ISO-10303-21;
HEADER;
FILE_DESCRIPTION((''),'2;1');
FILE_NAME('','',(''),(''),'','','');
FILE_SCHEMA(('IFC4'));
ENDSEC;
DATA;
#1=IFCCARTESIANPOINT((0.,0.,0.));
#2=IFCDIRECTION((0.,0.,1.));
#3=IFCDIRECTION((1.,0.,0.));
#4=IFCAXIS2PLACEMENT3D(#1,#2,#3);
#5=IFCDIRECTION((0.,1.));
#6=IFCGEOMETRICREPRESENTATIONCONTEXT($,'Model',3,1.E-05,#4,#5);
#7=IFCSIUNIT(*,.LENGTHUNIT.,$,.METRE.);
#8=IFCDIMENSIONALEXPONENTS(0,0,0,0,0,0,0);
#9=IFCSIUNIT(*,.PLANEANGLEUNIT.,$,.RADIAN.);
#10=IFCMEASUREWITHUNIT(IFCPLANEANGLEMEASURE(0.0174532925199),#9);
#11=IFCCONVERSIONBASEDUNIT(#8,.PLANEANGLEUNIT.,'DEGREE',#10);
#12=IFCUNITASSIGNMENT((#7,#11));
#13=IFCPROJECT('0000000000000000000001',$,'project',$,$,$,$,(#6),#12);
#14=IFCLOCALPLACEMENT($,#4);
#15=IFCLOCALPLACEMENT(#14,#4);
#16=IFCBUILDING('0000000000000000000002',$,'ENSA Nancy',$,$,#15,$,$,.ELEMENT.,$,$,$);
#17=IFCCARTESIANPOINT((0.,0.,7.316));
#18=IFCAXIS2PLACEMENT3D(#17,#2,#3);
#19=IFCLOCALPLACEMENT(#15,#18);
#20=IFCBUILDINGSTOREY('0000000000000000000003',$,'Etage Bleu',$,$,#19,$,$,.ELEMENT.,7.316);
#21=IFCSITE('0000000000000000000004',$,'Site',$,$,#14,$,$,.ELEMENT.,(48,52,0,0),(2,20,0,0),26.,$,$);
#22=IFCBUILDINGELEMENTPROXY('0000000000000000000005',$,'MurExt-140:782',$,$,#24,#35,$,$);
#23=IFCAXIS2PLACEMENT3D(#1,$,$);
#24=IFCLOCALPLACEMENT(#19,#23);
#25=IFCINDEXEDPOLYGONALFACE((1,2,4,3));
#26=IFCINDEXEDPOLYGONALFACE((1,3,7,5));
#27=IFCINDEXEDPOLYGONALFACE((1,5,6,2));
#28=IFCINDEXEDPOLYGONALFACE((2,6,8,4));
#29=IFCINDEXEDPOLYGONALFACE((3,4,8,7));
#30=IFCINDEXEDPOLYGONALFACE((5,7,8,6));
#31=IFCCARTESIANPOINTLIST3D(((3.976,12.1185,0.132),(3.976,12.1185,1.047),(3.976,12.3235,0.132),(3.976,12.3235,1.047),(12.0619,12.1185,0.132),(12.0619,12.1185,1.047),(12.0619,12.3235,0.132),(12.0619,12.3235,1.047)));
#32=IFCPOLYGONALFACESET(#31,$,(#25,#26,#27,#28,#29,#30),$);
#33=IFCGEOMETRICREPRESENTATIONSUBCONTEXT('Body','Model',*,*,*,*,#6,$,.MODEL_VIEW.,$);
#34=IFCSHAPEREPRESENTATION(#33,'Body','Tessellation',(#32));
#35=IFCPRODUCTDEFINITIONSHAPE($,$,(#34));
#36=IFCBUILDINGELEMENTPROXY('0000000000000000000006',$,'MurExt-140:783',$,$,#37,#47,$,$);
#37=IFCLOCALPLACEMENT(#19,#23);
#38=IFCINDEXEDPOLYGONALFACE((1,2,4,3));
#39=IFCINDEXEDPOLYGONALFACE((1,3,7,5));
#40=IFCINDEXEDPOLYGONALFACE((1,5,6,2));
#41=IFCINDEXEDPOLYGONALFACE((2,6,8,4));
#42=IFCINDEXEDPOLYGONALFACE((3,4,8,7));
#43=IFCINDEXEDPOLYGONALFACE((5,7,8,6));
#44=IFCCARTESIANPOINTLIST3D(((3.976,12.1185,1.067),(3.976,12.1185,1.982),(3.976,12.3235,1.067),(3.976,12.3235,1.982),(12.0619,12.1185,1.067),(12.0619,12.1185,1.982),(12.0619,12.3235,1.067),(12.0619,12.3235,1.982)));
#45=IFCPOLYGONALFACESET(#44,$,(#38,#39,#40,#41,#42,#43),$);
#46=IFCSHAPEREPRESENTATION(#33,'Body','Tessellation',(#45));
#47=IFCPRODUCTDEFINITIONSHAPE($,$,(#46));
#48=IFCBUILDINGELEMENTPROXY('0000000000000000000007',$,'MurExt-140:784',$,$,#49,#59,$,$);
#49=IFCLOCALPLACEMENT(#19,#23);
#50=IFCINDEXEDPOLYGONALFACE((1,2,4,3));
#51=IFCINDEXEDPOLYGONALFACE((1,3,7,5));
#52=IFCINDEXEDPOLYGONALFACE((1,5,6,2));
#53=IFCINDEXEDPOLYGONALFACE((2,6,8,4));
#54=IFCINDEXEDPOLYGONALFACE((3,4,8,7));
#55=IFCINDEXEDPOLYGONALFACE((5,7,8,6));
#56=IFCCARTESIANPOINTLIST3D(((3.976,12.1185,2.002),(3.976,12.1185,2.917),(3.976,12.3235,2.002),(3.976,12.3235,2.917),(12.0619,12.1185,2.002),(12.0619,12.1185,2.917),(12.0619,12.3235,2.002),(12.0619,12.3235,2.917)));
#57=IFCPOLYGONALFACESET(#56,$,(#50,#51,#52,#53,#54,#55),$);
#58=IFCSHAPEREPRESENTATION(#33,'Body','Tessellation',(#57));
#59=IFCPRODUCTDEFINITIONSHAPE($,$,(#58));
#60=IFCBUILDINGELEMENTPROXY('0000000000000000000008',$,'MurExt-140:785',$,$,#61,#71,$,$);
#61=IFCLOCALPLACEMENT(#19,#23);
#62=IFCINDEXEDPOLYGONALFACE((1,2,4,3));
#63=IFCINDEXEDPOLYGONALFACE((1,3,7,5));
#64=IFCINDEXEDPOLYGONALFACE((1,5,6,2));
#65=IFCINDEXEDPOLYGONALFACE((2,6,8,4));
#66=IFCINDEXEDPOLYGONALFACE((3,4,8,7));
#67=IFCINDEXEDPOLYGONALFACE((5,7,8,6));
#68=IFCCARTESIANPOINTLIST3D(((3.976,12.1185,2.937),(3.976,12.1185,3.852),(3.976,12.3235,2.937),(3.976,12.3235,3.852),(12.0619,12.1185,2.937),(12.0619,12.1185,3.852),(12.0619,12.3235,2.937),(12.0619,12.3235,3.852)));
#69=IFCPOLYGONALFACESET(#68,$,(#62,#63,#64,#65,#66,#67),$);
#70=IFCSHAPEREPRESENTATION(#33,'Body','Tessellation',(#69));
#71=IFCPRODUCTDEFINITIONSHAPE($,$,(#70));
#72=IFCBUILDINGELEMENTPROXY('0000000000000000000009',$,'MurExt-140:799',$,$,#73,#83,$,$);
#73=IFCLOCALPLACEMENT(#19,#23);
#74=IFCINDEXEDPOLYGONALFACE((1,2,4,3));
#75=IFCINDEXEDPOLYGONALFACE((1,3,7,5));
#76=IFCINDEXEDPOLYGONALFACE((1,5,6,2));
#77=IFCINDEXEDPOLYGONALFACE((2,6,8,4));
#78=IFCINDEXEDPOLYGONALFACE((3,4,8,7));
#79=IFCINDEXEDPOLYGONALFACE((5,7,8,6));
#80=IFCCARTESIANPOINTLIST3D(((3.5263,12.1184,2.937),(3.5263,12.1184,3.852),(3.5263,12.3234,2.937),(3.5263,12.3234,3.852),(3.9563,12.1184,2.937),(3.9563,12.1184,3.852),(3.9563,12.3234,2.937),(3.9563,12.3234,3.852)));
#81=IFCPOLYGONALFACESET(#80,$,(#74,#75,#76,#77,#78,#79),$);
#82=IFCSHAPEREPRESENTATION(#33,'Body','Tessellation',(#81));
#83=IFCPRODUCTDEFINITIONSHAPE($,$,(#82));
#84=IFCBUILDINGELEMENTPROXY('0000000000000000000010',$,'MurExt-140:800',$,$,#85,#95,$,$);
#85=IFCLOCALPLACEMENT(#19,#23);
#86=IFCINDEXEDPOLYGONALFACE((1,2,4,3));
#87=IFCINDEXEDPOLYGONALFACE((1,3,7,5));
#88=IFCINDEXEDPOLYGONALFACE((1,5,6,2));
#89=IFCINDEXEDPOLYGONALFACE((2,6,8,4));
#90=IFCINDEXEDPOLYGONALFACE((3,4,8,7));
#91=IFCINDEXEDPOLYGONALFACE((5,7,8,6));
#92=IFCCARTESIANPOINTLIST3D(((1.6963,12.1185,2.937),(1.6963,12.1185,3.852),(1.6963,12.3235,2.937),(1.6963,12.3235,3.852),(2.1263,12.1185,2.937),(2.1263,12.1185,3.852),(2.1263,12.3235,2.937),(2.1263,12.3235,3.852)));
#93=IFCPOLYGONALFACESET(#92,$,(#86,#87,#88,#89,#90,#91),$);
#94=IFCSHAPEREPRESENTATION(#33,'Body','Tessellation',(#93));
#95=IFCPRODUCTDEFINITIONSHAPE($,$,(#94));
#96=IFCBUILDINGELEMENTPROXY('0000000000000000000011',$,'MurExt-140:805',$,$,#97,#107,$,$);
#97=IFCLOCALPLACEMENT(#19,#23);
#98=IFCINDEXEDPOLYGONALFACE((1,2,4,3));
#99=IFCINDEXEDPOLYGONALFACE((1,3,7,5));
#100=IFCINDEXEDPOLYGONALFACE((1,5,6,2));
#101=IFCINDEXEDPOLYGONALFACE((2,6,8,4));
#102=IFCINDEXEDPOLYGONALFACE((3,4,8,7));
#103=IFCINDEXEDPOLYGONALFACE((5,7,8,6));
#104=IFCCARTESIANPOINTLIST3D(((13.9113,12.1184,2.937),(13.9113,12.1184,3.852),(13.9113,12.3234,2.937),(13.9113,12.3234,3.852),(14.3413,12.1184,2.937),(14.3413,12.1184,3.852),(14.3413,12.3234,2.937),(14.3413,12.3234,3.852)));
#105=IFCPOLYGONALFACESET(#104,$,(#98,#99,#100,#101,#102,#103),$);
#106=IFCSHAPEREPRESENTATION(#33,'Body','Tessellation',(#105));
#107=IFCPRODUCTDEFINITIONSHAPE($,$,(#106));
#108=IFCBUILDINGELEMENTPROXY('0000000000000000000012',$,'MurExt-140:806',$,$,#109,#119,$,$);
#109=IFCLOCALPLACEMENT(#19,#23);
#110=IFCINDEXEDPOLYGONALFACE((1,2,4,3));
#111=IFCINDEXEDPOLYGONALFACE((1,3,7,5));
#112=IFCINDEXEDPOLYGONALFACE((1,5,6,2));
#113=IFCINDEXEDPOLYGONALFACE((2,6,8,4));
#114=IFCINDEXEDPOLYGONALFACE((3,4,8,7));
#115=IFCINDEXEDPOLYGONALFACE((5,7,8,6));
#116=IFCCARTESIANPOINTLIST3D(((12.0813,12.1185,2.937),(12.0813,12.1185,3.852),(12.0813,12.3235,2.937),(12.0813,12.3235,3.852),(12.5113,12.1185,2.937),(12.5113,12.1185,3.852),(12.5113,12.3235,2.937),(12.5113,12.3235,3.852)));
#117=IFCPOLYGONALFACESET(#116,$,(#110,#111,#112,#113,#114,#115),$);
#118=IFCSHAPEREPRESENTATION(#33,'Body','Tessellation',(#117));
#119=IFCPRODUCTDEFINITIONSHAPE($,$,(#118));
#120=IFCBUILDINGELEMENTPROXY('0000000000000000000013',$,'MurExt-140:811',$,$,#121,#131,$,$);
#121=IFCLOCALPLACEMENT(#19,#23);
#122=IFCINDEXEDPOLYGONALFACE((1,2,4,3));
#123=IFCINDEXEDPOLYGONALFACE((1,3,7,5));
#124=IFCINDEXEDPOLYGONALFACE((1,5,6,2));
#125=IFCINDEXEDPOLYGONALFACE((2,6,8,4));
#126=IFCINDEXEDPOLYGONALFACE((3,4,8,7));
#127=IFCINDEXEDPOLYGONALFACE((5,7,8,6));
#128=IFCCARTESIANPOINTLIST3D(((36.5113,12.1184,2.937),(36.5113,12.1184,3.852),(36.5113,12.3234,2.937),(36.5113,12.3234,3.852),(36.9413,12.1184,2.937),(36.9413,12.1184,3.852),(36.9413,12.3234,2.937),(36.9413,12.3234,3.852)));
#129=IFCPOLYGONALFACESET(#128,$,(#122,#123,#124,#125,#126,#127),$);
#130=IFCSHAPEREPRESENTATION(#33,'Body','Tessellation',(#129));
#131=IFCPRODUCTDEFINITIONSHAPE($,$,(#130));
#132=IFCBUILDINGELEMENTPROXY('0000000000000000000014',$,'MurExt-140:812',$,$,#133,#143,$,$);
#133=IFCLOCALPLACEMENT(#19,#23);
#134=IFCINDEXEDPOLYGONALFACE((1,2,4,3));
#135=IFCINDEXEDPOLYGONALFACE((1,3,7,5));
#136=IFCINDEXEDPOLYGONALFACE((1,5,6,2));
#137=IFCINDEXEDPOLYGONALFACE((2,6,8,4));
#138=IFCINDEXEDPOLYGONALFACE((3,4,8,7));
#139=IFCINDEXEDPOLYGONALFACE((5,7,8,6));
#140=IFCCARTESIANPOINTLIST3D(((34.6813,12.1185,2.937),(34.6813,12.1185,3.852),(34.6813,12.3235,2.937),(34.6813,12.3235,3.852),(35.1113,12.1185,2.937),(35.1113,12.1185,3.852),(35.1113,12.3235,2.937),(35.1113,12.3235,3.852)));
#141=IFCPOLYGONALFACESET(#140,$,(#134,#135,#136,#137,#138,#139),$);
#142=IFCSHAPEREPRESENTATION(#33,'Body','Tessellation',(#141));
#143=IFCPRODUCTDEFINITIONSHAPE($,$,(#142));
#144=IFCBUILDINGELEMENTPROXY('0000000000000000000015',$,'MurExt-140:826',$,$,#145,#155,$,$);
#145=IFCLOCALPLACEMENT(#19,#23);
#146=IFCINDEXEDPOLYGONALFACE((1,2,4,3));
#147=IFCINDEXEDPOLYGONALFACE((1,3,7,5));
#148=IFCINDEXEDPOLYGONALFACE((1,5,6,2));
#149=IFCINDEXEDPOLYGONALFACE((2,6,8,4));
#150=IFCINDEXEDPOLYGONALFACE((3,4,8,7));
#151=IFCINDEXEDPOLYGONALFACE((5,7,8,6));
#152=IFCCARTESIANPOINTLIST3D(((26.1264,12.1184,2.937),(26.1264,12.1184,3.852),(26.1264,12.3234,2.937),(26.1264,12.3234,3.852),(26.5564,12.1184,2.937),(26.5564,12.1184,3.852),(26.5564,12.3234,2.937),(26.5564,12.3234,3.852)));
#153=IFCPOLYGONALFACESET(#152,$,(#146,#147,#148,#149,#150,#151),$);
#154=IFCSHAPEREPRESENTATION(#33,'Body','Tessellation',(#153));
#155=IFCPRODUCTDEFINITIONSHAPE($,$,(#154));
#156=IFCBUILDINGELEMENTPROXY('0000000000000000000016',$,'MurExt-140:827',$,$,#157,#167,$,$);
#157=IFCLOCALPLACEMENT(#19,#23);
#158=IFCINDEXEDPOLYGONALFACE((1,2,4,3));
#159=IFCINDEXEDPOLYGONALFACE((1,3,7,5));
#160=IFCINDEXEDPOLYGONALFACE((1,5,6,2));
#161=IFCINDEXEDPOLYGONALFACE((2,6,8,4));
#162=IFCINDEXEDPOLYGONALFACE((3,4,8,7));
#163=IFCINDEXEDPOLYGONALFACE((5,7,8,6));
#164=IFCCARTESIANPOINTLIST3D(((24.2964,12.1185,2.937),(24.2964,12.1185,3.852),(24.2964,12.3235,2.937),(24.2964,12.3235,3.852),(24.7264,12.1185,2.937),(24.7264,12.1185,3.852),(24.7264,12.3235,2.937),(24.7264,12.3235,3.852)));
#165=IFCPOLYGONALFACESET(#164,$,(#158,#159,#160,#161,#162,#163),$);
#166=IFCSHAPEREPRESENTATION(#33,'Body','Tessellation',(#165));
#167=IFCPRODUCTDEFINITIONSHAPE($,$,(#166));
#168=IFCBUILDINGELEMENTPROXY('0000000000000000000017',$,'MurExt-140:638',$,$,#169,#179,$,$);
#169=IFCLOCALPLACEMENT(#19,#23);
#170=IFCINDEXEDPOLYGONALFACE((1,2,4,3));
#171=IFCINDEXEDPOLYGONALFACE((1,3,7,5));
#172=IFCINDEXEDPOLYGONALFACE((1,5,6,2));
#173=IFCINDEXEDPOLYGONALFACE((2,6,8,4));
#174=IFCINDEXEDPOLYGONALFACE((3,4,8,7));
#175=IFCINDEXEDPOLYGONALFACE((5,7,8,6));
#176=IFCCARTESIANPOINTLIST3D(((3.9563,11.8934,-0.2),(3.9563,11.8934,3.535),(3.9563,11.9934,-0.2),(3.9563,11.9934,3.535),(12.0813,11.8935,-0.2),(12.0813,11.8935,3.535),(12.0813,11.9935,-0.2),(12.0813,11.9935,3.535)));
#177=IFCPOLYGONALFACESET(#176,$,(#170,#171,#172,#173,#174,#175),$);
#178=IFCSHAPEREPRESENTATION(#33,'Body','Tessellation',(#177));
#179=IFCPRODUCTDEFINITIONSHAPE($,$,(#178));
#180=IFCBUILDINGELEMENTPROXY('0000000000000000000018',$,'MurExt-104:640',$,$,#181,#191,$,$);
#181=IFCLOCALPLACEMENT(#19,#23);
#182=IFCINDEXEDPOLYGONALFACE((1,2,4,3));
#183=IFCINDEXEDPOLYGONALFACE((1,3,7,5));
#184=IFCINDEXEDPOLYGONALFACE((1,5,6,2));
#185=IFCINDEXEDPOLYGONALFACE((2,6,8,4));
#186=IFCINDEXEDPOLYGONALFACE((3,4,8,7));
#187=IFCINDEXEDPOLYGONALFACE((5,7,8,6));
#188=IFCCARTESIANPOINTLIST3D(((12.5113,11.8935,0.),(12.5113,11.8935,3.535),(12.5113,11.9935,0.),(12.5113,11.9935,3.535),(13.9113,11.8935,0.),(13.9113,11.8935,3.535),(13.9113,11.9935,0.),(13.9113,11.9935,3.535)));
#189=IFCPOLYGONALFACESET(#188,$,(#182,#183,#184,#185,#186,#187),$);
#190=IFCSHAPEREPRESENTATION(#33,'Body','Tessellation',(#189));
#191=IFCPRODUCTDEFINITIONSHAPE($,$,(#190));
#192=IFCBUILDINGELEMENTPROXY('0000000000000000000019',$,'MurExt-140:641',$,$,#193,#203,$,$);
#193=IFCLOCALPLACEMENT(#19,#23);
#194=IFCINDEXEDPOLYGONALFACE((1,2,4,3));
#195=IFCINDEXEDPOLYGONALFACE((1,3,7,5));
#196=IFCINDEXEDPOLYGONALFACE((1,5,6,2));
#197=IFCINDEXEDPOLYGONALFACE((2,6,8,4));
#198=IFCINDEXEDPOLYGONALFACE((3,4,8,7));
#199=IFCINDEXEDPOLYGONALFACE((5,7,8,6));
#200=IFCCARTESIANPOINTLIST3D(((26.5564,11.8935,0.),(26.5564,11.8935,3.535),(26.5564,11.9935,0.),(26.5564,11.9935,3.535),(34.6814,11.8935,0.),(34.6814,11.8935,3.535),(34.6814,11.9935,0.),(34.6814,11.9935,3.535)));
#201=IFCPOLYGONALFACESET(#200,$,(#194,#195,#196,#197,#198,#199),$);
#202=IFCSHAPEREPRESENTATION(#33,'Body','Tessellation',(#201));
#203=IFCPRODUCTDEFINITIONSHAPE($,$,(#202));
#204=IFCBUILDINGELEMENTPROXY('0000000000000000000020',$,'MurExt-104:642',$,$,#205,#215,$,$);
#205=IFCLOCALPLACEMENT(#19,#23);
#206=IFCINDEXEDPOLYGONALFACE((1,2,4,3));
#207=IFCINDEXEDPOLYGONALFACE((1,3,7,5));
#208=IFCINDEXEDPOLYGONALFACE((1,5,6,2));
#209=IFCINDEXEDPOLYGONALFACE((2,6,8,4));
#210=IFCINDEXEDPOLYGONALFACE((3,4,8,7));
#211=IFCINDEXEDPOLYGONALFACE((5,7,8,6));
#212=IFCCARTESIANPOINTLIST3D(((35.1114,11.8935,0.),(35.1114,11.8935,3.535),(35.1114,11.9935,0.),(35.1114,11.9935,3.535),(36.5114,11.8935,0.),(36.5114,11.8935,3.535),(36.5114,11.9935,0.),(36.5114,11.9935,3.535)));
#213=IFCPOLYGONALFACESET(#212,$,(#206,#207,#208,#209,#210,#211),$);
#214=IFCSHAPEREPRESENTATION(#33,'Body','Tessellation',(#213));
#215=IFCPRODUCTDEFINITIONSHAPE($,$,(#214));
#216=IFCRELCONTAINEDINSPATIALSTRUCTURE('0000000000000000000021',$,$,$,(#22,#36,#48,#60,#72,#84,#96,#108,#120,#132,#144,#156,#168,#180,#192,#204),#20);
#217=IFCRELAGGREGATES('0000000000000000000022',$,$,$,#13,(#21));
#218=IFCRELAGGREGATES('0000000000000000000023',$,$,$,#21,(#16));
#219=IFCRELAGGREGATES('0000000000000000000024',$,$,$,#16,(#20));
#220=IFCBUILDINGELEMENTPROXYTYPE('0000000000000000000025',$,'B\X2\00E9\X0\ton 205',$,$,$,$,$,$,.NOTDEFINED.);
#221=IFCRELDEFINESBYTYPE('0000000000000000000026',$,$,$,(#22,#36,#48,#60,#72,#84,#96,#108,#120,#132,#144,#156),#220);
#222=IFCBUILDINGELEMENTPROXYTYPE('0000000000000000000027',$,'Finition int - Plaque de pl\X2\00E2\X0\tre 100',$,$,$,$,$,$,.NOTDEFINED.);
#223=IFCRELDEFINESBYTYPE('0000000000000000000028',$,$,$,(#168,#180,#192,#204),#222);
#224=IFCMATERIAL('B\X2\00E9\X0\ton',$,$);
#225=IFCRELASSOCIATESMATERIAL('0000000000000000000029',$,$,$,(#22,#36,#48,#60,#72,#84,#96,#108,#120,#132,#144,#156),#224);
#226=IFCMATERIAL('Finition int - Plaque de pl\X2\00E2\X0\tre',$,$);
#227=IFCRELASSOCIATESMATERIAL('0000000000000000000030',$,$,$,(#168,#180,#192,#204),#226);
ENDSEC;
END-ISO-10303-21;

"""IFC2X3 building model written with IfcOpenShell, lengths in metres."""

from ifc_helpers import new_model, entity, si_unit, converted_unit, direction, frame, origin_with_axes, place, context, subcontext, project, spatial, polyline, outline, extrude, material, type_object, element, save


model = new_model("IFC2X3")

# Units and contexts
model_context = context("Model", 3, precision=1e-05, world=origin_with_axes(), true_north=direction((0.0, 1.0)))
body_context = subcontext(model_context, "Body", "Model", "MODEL_VIEW")
ifc_project = project(units=[si_unit("LENGTHUNIT", "METRE"), converted_unit("PLANEANGLEUNIT", "DEGREE", entity("IfcPlaneAngleMeasure", 0.0174532925199), si_unit("PLANEANGLEUNIT", "RADIAN"), dimensions=[0, 0, 0, 0, 0, 0, 0])], contexts=[model_context])

# Site, building, storey
site_placement = place(None, origin_with_axes())
site = spatial("IfcSite", under=ifc_project, at=site_placement, Name="Site", CompositionType="ELEMENT", RefLatitude=(48, 52, 0, 0), RefLongitude=(2, 20, 0, 0), RefElevation=26.0)
building_placement = place(site_placement, origin_with_axes())
building = spatial("IfcBuilding", under=site, at=building_placement, Name="ENSA Nancy", CompositionType="ELEMENT")
storey_placement = place(building_placement, frame((0.0, 0.0, 7.316), z_axis=(0.0, 0.0, 1.0), x_axis=(1.0, 0.0, 0.0)))
storey = spatial("IfcBuildingStorey", under=building, at=storey_placement, Name="Etage Bleu", CompositionType="ELEMENT", Elevation=7.316)

# Shared definitions
ifc_material_1 = material(Name="Finition int - Plaque de plâtre")

# Shared definitions
ifc_material_2 = material(Name="Béton")

# Building element proxies
building_element_proxy_type_1 = type_object("IfcBuildingElementProxyType", Name="Béton 205", PredefinedType="NOTDEFINED")
for number, where, z_axis, x_axis, name in (
    (1, (3.976, 12.3235, 0.132), (0.0, 0.0, 1.0), (1.0, 0.0, 0.0), "MurExt-140:782"),
    (2, (3.976, 12.3235, 1.067), (0.0, 0.0, 1.0), (1.0, 0.0, 0.0), "MurExt-140:783"),
    (3, (3.976, 12.3235, 2.002), (0.0, 0.0, 1.0), (1.0, 0.0, 0.0), "MurExt-140:784"),
    (4, (3.976, 12.3235, 2.937), (0.0, 0.0, 1.0), (1.0, 0.0, 0.0), "MurExt-140:785"),
):
    element("IfcBuildingElementProxy", number, at=place(storey_placement, frame(where, z_axis=z_axis, x_axis=x_axis)), inside=storey, type_object=building_element_proxy_type_1, material=ifc_material_2, Name=name, context=body_context, shape_type="SweptSolid", body=[
        extrude(outline(polyline([(0.0, -0.205), (8.0859, -0.205), (8.0859, 0.0), (0.0, 0.0), (0.0, -0.205)])), origin_with_axes(), (0.0, 0.0, 1.0), 0.915),
    ])
for number, where, z_axis, x_axis, name in (
    (5, (3.5263, 12.3234, 2.937), (0.0, 0.0, 1.0), (1.0, 0.0, 0.0), "MurExt-140:799"),
    (6, (1.6963, 12.3235, 2.937), (0.0, 0.0, 1.0), (1.0, 0.0, 0.0), "MurExt-140:800"),
    (7, (13.9113, 12.3234, 2.937), (0.0, 0.0, 1.0), (1.0, 0.0, 0.0), "MurExt-140:805"),
    (8, (12.0813, 12.3235, 2.937), (0.0, 0.0, 1.0), (1.0, 0.0, 0.0), "MurExt-140:806"),
    (9, (36.5113, 12.3234, 2.937), (0.0, 0.0, 1.0), (1.0, 0.0, 0.0), "MurExt-140:811"),
    (10, (34.6813, 12.3235, 2.937), (0.0, 0.0, 1.0), (1.0, 0.0, 0.0), "MurExt-140:812"),
    (11, (26.1264, 12.3234, 2.937), (0.0, 0.0, 1.0), (1.0, 0.0, 0.0), "MurExt-140:826"),
    (12, (24.2964, 12.3235, 2.937), (0.0, 0.0, 1.0), (1.0, 0.0, 0.0), "MurExt-140:827"),
):
    element("IfcBuildingElementProxy", number, at=place(storey_placement, frame(where, z_axis=z_axis, x_axis=x_axis)), inside=storey, type_object=building_element_proxy_type_1, material=ifc_material_2, Name=name, context=body_context, shape_type="SweptSolid", body=[
        extrude(outline(polyline([(0.0, -0.205), (0.43, -0.205), (0.43, 0.0), (0.0, 0.0), (0.0, -0.205)])), origin_with_axes(), (0.0, 0.0, 1.0), 0.915),
    ])
building_element_proxy_type_2 = type_object("IfcBuildingElementProxyType", Name="Finition int - Plaque de plâtre 100", PredefinedType="NOTDEFINED")
proxy_1_placement = place(storey_placement, frame((3.9563, 11.8934, -0.2), z_axis=(0.0, 0.0, 1.0), x_axis=(1.0, 0.000006, 0.0)))
element("IfcBuildingElementProxy", 13, at=proxy_1_placement, inside=storey, type_object=building_element_proxy_type_2, material=ifc_material_1, Name="MurExt-140:638", context=body_context, shape_type="SweptSolid", body=[
    extrude(outline(polyline([(0.0, 0.0), (8.125, 0.0), (8.125, 0.1), (0.0, 0.1), (0.0, 0.0)])), origin_with_axes(), (0.0, 0.0, 1.0), 3.735),
])
proxy_2_placement = place(storey_placement, frame((12.5113, 11.8935, 0.0), z_axis=(0.0, 0.0, 1.0), x_axis=(1.0, 0.0, 0.0)))
element("IfcBuildingElementProxy", 14, at=proxy_2_placement, inside=storey, type_object=building_element_proxy_type_2, material=ifc_material_1, Name="MurExt-104:640", context=body_context, shape_type="SweptSolid", body=[
    extrude(outline(polyline([(0.0, 0.0), (1.4, 0.0), (1.4, 0.1), (0.0, 0.1), (0.0, 0.0)])), origin_with_axes(), (0.0, 0.0, 1.0), 3.535),
])
proxy_3_placement = place(storey_placement, frame((26.5564, 11.8935, 0.0), z_axis=(0.0, 0.0, 1.0), x_axis=(1.0, 0.0, 0.0)))
element("IfcBuildingElementProxy", 15, at=proxy_3_placement, inside=storey, type_object=building_element_proxy_type_2, material=ifc_material_1, Name="MurExt-140:641", context=body_context, shape_type="SweptSolid", body=[
    extrude(outline(polyline([(0.0, 0.0), (8.125, 0.0), (8.125, 0.1), (0.0, 0.1), (0.0, 0.0)])), origin_with_axes(), (0.0, 0.0, 1.0), 3.535),
])
proxy_4_placement = place(storey_placement, frame((35.1114, 11.8935, 0.0), z_axis=(0.0, 0.0, 1.0), x_axis=(1.0, 0.0, 0.0)))
element("IfcBuildingElementProxy", 16, at=proxy_4_placement, inside=storey, type_object=building_element_proxy_type_2, material=ifc_material_1, Name="MurExt-104:642", context=body_context, shape_type="SweptSolid", body=[
    extrude(outline(polyline([(0.0, 0.0), (1.4, 0.0), (1.4, 0.1), (0.0, 0.1), (0.0, 0.0)])), origin_with_axes(), (0.0, 0.0, 1.0), 3.535),
])

save(model, "model.ifc")
